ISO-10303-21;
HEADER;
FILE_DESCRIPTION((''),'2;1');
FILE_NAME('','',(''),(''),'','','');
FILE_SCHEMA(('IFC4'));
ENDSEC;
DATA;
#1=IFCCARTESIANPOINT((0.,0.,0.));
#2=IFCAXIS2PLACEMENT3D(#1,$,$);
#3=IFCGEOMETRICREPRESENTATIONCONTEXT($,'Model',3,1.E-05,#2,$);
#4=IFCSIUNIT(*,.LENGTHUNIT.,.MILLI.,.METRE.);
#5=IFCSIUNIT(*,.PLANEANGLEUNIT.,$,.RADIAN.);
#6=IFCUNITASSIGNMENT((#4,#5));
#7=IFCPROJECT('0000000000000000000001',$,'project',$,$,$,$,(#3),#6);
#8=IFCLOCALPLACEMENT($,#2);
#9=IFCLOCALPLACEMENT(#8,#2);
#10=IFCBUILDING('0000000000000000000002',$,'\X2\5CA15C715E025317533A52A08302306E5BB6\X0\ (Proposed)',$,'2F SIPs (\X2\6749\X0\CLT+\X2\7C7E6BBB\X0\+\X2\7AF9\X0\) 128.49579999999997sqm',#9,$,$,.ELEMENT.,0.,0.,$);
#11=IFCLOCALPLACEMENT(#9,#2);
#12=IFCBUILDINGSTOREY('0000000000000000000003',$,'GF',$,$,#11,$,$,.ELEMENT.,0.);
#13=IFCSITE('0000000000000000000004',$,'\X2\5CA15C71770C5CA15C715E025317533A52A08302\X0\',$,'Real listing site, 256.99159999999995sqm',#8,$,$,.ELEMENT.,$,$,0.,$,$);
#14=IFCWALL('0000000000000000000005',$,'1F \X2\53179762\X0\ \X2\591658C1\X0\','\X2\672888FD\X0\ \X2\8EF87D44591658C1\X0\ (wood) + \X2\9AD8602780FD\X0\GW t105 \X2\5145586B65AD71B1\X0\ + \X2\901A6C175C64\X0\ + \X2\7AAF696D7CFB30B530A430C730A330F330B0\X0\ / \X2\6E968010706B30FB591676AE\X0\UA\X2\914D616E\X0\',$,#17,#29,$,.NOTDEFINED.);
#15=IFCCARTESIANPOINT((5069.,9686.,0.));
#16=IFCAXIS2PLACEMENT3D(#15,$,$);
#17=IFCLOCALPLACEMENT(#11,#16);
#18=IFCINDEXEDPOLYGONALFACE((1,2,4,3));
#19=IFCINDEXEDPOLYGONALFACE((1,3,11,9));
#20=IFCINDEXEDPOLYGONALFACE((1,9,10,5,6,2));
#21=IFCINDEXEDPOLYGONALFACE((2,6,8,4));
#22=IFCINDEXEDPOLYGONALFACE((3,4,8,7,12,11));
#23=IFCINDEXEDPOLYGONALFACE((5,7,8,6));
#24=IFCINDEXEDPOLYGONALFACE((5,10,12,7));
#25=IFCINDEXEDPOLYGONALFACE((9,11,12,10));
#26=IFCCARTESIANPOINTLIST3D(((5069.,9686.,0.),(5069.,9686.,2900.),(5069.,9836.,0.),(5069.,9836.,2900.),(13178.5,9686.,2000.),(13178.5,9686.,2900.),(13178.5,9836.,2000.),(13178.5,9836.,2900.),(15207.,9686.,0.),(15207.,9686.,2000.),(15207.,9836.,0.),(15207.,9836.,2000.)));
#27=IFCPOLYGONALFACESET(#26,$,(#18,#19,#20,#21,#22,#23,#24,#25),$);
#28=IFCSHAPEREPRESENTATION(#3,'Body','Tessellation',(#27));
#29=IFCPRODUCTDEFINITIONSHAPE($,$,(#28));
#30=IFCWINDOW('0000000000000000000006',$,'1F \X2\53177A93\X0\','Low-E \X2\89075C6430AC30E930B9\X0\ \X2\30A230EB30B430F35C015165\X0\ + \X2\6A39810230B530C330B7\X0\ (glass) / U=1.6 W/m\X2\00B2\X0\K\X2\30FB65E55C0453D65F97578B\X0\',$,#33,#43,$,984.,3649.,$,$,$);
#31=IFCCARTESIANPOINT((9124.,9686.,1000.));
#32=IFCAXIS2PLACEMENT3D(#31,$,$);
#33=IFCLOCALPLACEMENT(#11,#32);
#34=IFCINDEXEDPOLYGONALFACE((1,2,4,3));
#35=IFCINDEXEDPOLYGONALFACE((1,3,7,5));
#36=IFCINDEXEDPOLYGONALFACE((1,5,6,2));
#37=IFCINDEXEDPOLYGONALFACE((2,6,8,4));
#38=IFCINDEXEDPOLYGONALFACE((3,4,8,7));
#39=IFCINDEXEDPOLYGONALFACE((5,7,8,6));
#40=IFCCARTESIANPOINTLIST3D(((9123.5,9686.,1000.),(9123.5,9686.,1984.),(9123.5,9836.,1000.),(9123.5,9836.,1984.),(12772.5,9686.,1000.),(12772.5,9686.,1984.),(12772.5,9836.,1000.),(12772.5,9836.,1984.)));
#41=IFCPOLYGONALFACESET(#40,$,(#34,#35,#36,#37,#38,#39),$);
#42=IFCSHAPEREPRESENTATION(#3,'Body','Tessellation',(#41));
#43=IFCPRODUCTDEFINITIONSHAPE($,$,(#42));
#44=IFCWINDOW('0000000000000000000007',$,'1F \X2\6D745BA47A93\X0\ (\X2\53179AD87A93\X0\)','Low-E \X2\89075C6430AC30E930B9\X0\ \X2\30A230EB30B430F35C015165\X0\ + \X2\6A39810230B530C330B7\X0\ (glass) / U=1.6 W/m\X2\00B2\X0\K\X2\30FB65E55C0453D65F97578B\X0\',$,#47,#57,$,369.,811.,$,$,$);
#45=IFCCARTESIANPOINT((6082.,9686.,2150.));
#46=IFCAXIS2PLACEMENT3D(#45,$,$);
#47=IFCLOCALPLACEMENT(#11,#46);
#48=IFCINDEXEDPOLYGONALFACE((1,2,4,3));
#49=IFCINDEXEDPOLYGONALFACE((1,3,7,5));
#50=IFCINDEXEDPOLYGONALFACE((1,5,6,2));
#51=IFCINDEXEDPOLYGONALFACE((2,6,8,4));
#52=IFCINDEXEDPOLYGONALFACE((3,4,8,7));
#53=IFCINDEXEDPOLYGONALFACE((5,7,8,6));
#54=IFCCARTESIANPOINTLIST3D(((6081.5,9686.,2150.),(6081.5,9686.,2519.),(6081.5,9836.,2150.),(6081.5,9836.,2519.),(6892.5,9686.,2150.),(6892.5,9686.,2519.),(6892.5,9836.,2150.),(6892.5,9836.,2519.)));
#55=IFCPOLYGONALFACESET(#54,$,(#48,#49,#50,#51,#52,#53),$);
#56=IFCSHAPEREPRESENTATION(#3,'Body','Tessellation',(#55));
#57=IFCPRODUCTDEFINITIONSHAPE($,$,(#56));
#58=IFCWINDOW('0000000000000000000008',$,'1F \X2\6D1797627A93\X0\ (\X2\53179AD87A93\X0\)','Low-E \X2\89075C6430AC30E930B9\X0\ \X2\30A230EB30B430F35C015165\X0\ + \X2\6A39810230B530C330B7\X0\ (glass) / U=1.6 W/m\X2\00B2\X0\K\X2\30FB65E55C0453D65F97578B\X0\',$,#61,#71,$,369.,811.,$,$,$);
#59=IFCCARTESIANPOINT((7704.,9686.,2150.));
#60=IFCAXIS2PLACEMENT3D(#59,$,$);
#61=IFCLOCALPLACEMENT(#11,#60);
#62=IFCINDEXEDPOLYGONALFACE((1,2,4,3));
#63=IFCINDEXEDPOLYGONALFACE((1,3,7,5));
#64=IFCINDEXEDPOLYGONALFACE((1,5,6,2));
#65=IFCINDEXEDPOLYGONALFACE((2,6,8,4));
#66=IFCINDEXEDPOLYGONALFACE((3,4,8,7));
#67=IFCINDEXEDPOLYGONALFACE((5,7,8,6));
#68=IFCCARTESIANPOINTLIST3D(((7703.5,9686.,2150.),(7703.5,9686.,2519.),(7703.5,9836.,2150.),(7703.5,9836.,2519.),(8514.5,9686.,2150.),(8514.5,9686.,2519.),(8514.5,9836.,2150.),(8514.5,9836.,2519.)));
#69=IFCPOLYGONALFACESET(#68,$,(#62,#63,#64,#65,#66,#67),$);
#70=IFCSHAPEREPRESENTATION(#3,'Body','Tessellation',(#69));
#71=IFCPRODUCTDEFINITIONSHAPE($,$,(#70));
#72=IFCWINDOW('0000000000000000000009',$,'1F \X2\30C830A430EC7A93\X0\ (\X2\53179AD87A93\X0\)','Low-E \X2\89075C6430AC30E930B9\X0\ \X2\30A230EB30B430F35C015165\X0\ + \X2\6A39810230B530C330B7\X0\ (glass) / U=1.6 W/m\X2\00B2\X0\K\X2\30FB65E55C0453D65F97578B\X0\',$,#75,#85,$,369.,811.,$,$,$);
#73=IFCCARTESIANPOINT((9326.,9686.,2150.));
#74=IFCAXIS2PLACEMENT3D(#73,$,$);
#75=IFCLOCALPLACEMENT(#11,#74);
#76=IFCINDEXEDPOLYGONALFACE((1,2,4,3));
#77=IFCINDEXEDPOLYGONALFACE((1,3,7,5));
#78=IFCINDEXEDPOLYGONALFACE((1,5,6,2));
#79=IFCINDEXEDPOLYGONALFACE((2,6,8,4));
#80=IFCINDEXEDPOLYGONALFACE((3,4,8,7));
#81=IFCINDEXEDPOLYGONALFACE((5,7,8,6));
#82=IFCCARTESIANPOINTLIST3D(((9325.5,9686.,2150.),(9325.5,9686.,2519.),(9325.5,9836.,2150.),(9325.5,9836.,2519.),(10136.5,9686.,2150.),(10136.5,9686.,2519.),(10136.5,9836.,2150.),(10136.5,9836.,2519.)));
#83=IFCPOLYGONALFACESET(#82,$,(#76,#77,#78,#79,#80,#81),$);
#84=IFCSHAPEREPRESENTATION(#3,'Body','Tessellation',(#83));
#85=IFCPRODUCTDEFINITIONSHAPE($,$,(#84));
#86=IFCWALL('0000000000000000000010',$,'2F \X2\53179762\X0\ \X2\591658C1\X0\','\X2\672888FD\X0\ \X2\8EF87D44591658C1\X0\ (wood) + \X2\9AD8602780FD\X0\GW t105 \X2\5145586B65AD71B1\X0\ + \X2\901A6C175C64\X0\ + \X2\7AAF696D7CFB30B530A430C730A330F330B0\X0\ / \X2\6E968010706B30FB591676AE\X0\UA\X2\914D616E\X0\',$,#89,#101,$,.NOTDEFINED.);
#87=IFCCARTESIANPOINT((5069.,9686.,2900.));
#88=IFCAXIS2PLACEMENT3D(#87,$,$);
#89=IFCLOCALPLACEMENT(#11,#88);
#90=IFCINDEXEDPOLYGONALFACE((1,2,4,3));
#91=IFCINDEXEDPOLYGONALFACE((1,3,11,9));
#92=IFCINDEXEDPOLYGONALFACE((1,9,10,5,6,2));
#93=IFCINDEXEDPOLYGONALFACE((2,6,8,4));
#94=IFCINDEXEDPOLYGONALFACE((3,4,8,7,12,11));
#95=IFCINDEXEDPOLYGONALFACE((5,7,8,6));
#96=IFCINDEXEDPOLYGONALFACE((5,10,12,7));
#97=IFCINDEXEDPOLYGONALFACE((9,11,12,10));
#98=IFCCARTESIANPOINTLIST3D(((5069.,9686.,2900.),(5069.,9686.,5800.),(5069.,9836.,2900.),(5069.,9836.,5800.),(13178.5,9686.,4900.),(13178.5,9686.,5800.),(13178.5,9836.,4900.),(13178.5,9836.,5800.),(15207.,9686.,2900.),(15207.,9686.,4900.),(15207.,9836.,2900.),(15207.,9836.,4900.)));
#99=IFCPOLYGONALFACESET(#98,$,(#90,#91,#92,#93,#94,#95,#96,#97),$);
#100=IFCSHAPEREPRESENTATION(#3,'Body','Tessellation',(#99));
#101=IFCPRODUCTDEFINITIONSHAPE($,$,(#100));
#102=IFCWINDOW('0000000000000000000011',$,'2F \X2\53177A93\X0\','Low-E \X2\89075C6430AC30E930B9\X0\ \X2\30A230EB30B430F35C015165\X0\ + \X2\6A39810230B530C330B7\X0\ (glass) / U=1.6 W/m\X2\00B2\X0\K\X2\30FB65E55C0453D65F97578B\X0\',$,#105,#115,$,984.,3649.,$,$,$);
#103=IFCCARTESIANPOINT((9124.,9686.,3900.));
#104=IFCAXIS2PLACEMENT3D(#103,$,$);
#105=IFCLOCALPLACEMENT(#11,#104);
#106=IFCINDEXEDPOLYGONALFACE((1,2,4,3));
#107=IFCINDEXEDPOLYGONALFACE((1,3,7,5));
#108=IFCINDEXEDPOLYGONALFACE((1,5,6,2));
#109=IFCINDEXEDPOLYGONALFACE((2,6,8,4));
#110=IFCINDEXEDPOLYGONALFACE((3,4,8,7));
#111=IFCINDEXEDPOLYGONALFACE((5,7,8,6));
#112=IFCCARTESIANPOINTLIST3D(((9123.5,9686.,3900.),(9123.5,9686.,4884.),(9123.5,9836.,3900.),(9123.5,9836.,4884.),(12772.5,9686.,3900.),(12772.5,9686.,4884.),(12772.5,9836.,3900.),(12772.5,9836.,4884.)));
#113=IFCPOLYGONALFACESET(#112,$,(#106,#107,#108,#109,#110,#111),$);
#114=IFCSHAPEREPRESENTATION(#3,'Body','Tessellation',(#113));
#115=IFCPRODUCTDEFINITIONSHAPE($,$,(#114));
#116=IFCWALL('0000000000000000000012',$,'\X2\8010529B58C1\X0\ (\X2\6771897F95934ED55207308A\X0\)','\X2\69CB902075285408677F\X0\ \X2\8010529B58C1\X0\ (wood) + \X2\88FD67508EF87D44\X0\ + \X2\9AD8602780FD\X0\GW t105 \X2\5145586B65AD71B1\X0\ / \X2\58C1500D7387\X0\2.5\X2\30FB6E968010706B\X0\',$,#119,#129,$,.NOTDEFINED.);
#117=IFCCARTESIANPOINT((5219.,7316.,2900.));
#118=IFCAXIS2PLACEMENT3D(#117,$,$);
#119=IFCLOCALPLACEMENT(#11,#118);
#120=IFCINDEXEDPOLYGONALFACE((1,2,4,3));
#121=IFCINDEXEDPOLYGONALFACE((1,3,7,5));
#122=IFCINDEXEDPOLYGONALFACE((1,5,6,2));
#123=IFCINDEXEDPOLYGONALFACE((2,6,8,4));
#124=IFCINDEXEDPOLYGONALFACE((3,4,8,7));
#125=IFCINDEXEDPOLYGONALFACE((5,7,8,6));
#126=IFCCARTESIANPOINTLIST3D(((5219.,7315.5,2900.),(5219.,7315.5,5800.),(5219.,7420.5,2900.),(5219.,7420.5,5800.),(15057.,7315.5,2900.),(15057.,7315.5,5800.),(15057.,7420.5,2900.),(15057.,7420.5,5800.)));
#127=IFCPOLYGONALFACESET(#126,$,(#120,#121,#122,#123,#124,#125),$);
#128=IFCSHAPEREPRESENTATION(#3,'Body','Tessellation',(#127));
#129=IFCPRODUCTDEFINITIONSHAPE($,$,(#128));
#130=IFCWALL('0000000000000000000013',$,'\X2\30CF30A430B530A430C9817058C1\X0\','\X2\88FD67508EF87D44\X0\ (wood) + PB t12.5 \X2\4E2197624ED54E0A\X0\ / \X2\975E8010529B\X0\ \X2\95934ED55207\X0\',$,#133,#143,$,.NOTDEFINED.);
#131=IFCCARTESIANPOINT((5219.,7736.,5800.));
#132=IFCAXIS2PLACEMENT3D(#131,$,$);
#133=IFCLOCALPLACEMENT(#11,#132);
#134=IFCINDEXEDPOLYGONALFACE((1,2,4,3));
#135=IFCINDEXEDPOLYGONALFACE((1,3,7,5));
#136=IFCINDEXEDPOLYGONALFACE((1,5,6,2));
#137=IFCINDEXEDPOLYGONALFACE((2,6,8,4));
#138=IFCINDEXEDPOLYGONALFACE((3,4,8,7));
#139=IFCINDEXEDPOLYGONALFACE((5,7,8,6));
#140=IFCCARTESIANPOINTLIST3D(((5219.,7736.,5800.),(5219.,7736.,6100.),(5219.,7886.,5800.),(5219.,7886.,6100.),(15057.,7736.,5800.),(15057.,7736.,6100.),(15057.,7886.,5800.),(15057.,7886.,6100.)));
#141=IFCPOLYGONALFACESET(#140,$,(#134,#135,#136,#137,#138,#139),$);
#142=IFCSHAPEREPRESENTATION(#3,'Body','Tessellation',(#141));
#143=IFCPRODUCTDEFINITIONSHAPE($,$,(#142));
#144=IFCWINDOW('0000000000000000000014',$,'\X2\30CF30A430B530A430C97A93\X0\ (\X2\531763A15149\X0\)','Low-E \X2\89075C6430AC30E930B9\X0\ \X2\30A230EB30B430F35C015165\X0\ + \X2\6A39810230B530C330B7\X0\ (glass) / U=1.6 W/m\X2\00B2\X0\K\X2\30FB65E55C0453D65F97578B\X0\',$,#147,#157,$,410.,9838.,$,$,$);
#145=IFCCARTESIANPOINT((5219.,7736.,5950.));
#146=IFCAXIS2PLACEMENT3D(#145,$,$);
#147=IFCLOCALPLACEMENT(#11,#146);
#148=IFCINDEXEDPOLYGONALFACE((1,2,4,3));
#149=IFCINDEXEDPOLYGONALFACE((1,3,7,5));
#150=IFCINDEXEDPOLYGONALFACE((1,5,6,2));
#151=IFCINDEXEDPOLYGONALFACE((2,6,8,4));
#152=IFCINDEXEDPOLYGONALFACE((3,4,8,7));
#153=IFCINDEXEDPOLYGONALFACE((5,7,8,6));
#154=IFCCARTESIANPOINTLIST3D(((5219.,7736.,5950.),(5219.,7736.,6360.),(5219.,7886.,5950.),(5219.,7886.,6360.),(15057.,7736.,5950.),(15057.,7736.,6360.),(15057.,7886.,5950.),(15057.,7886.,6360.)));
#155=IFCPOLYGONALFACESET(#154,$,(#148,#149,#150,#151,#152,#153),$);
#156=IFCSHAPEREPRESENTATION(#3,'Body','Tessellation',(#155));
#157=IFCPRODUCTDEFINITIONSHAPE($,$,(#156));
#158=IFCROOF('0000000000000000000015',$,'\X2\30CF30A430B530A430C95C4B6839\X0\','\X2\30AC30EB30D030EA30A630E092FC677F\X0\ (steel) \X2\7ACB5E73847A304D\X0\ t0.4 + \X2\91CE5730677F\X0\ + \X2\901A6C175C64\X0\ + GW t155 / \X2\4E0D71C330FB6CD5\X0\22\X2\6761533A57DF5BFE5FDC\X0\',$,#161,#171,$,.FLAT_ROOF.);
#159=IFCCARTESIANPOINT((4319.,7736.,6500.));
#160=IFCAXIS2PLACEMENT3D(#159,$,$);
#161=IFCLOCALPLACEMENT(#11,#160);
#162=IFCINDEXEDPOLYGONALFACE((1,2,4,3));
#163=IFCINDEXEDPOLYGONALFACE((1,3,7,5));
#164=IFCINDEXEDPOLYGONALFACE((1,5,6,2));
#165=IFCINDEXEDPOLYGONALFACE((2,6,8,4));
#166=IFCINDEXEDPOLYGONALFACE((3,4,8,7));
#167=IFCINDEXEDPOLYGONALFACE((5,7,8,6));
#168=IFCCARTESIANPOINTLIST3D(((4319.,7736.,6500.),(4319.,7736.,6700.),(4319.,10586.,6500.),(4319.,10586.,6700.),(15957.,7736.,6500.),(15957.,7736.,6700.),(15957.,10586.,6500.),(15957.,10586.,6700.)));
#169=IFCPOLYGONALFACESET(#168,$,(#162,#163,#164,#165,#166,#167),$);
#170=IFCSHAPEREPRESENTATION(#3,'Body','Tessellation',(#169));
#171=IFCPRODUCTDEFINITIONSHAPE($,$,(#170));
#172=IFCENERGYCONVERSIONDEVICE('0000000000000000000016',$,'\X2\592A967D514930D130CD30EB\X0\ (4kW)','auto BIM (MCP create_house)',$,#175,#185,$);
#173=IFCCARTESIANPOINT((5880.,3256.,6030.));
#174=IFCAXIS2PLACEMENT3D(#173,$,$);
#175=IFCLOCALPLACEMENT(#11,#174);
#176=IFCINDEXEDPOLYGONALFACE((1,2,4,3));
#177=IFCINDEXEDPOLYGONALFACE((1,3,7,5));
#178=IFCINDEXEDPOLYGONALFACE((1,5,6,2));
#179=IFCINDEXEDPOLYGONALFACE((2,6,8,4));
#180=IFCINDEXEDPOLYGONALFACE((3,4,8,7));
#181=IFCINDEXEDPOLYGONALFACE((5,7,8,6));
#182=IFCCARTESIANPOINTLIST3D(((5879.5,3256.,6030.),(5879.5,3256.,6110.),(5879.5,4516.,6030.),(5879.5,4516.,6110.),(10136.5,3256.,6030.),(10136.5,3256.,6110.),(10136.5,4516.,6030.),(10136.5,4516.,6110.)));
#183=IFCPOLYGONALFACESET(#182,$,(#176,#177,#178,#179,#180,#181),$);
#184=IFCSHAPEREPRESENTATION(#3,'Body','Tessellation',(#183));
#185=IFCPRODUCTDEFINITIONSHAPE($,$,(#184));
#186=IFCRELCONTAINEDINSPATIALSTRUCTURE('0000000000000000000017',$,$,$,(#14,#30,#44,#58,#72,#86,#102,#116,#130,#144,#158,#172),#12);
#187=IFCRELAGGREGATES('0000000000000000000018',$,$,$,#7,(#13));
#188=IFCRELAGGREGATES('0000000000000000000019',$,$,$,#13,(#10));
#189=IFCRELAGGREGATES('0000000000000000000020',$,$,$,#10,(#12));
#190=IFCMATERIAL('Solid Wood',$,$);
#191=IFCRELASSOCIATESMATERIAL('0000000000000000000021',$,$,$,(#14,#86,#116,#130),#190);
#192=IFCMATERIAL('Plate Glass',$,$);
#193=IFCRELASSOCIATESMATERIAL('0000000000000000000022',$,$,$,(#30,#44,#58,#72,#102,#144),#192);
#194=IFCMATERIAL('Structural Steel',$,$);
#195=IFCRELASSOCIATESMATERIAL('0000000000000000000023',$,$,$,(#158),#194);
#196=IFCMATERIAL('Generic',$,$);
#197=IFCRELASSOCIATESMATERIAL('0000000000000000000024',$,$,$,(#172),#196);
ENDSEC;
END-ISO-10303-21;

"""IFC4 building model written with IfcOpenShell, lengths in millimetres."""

from ifc_helpers import new_model, si_unit, frame, frame_2d, origin, place, context, project, spatial, rectangle, extrude, material, element, fill, save


model = new_model("IFC4")

# Units and contexts
model_context = context("Model", 3, precision=1e-05, world=origin())
ifc_project = project(units=[si_unit("LENGTHUNIT", "METRE", prefix="MILLI"), si_unit("PLANEANGLEUNIT", "RADIAN")], contexts=[model_context])

# Site, building, storey
site_placement = place(None, origin())
site = spatial("IfcSite", under=ifc_project, at=site_placement, Name="岡山県岡山市北区加茂", ObjectType="Real listing site, 256.99159999999995sqm", CompositionType="ELEMENT", RefElevation=0.0)
building_placement = place(site_placement, origin())
building = spatial("IfcBuilding", under=site, at=building_placement, Name="岡山市北区加茂の家 (Proposed)", ObjectType="2F SIPs (杉CLT+籾殻+竹) 128.49579999999997sqm", CompositionType="ELEMENT", ElevationOfRefHeight=0.0, ElevationOfTerrain=0.0)
storey_placement = place(building_placement, origin())
storey = spatial("IfcBuildingStorey", under=building, at=storey_placement, Name="GF", CompositionType="ELEMENT", Elevation=0.0)

# Wall, openings, windows
ifc_material_1 = material(Name="Solid Wood")
wall_1_placement = place(storey_placement, frame((5069.0, 9686.0, 0.0)))
wall_1 = element("IfcWall", 1, at=wall_1_placement, inside=storey, material=ifc_material_1, Name="1F 北面 外壁", Description="木製 軸組外壁 (wood) + 高性能GW t105 充填断熱 + 通気層 + 窯業系サイディング / 準耐火・外皮UA配慮", PredefinedType="NOTDEFINED", context=model_context, shape_type="SweptSolid", body=[
    extrude(rectangle(XDim=10138.0, YDim=150.0, at=frame_2d((5069.0, 75.0))), frame((5069.0, 9686.0, 0.0)), (0.0, 0.0, 1.0), 2900.0),
])
opening_1_placement = place(storey_placement, frame((9124.0, 9686.0, 1000.0)))
opening_1 = element("IfcOpeningElement", 2, at=opening_1_placement, cuts=wall_1, PredefinedType="NOTDEFINED", context=model_context, shape_type="SweptSolid", body=[
    extrude(rectangle(XDim=3649.0, YDim=150.0, at=frame_2d((1824.0, 75.0))), frame((9124.0, 9686.0, 1000.0)), (0.0, 0.0, 1.0), 984.0),
])
opening_2_placement = place(storey_placement, frame((6082.0, 9686.0, 2150.0)))
opening_2 = element("IfcOpeningElement", 3, at=opening_2_placement, cuts=wall_1, PredefinedType="NOTDEFINED", context=model_context, shape_type="SweptSolid", body=[
    extrude(rectangle(XDim=811.0, YDim=150.0, at=frame_2d((405.0, 75.0))), frame((6082.0, 9686.0, 2150.0)), (0.0, 0.0, 1.0), 369.0),
])
opening_3_placement = place(storey_placement, frame((7704.0, 9686.0, 2150.0)))
opening_3 = element("IfcOpeningElement", 4, at=opening_3_placement, cuts=wall_1, PredefinedType="NOTDEFINED", context=model_context, shape_type="SweptSolid", body=[
    extrude(rectangle(XDim=811.0, YDim=150.0, at=frame_2d((405.0, 75.0))), frame((7704.0, 9686.0, 2150.0)), (0.0, 0.0, 1.0), 369.0),
])
opening_4_placement = place(storey_placement, frame((9326.0, 9686.0, 2150.0)))
opening_4 = element("IfcOpeningElement", 5, at=opening_4_placement, cuts=wall_1, PredefinedType="NOTDEFINED", context=model_context, shape_type="SweptSolid", body=[
    extrude(rectangle(XDim=811.0, YDim=150.0, at=frame_2d((405.0, 75.0))), frame((9326.0, 9686.0, 2150.0)), (0.0, 0.0, 1.0), 369.0),
])
ifc_material_2 = material(Name="Plate Glass")
window_1_placement = place(storey_placement, frame((9124.0, 9686.0, 1000.0)))
window_1 = element("IfcWindow", 6, at=window_1_placement, inside=storey, material=ifc_material_2, Name="1F 北窓", Description="Low-E 複層ガラス アルゴン封入 + 樹脂サッシ (glass) / U=1.6 W/m²K・日射取得型", OverallHeight=984.0, OverallWidth=3649.0, context=model_context, shape_type="SweptSolid", body=[
    extrude(rectangle(XDim=3649.0, YDim=150.0, at=frame_2d((1824.0, 75.0))), frame((9124.0, 9686.0, 1000.0)), (0.0, 0.0, 1.0), 984.0),
])
fill(opening_1, window_1)
window_2_placement = place(storey_placement, frame((6082.0, 9686.0, 2150.0)))
window_2 = element("IfcWindow", 7, at=window_2_placement, inside=storey, material=ifc_material_2, Name="1F 浴室窓 (北高窓)", Description="Low-E 複層ガラス アルゴン封入 + 樹脂サッシ (glass) / U=1.6 W/m²K・日射取得型", OverallHeight=369.0, OverallWidth=811.0, context=model_context, shape_type="SweptSolid", body=[
    extrude(rectangle(XDim=811.0, YDim=150.0, at=frame_2d((405.0, 75.0))), frame((6082.0, 9686.0, 2150.0)), (0.0, 0.0, 1.0), 369.0),
])
fill(opening_2, window_2)
window_3_placement = place(storey_placement, frame((7704.0, 9686.0, 2150.0)))
window_3 = element("IfcWindow", 8, at=window_3_placement, inside=storey, material=ifc_material_2, Name="1F 洗面窓 (北高窓)", Description="Low-E 複層ガラス アルゴン封入 + 樹脂サッシ (glass) / U=1.6 W/m²K・日射取得型", OverallHeight=369.0, OverallWidth=811.0, context=model_context, shape_type="SweptSolid", body=[
    extrude(rectangle(XDim=811.0, YDim=150.0, at=frame_2d((405.0, 75.0))), frame((7704.0, 9686.0, 2150.0)), (0.0, 0.0, 1.0), 369.0),
])
fill(opening_3, window_3)
window_4_placement = place(storey_placement, frame((9326.0, 9686.0, 2150.0)))
window_4 = element("IfcWindow", 9, at=window_4_placement, inside=storey, material=ifc_material_2, Name="1F トイレ窓 (北高窓)", Description="Low-E 複層ガラス アルゴン封入 + 樹脂サッシ (glass) / U=1.6 W/m²K・日射取得型", OverallHeight=369.0, OverallWidth=811.0, context=model_context, shape_type="SweptSolid", body=[
    extrude(rectangle(XDim=811.0, YDim=150.0, at=frame_2d((405.0, 75.0))), frame((9326.0, 9686.0, 2150.0)), (0.0, 0.0, 1.0), 369.0),
])
fill(opening_4, window_4)

# Wall, opening, window
wall_2_placement = place(storey_placement, frame((5069.0, 9686.0, 2900.0)))
wall_2 = element("IfcWall", 10, at=wall_2_placement, inside=storey, material=ifc_material_1, Name="2F 北面 外壁", Description="木製 軸組外壁 (wood) + 高性能GW t105 充填断熱 + 通気層 + 窯業系サイディング / 準耐火・外皮UA配慮", PredefinedType="NOTDEFINED", context=model_context, shape_type="SweptSolid", body=[
    extrude(rectangle(XDim=10138.0, YDim=150.0, at=frame_2d((5069.0, 75.0))), frame((5069.0, 9686.0, 2900.0)), (0.0, 0.0, 1.0), 2900.0),
])
opening_5_placement = place(storey_placement, frame((9124.0, 9686.0, 3900.0)))
opening_5 = element("IfcOpeningElement", 11, at=opening_5_placement, cuts=wall_2, PredefinedType="NOTDEFINED", context=model_context, shape_type="SweptSolid", body=[
    extrude(rectangle(XDim=3649.0, YDim=150.0, at=frame_2d((1824.0, 75.0))), frame((9124.0, 9686.0, 3900.0)), (0.0, 0.0, 1.0), 984.0),
])
window_5_placement = place(storey_placement, frame((9124.0, 9686.0, 3900.0)))
window_5 = element("IfcWindow", 12, at=window_5_placement, inside=storey, material=ifc_material_2, Name="2F 北窓", Description="Low-E 複層ガラス アルゴン封入 + 樹脂サッシ (glass) / U=1.6 W/m²K・日射取得型", OverallHeight=984.0, OverallWidth=3649.0, context=model_context, shape_type="SweptSolid", body=[
    extrude(rectangle(XDim=3649.0, YDim=150.0, at=frame_2d((1824.0, 75.0))), frame((9124.0, 9686.0, 3900.0)), (0.0, 0.0, 1.0), 984.0),
])
fill(opening_5, window_5)

# Wall
wall_3_placement = place(storey_placement, frame((5219.0, 7316.0, 2900.0)))
element("IfcWall", 13, at=wall_3_placement, inside=storey, material=ifc_material_1, Name="耐力壁 (東西間仕切り)", Description="構造用合板 耐力壁 (wood) + 製材軸組 + 高性能GW t105 充填断熱 / 壁倍率2.5・準耐火", PredefinedType="NOTDEFINED", context=model_context, shape_type="SweptSolid", body=[
    extrude(rectangle(XDim=9838.0, YDim=105.0, at=frame_2d((4919.0, 52.0))), frame((5219.0, 7316.0, 2900.0)), (0.0, 0.0, 1.0), 2900.0),
])

# Wall, opening, window
wall_4_placement = place(storey_placement, frame((5219.0, 7736.0, 5800.0)))
wall_4 = element("IfcWall", 14, at=wall_4_placement, inside=storey, material=ifc_material_1, Name="ハイサイド腰壁", Description="製材軸組 (wood) + PB t12.5 両面仕上 / 非耐力 間仕切", PredefinedType="NOTDEFINED", context=model_context, shape_type="SweptSolid", body=[
    extrude(rectangle(XDim=9838.0, YDim=150.0, at=frame_2d((4919.0, 75.0))), frame((5219.0, 7736.0, 5800.0)), (0.0, 0.0, 1.0), 700.0),
])
opening_6_placement = place(storey_placement, frame((5219.0, 7736.0, 5950.0)))
opening_6 = element("IfcOpeningElement", 15, at=opening_6_placement, cuts=wall_4, PredefinedType="NOTDEFINED", context=model_context, shape_type="SweptSolid", body=[
    extrude(rectangle(XDim=9838.0, YDim=150.0, at=frame_2d((4919.0, 75.0))), frame((5219.0, 7736.0, 5950.0)), (0.0, 0.0, 1.0), 410.0),
])
window_6_placement = place(storey_placement, frame((5219.0, 7736.0, 5950.0)))
window_6 = element("IfcWindow", 16, at=window_6_placement, inside=storey, material=ifc_material_2, Name="ハイサイド窓 (北採光)", Description="Low-E 複層ガラス アルゴン封入 + 樹脂サッシ (glass) / U=1.6 W/m²K・日射取得型", OverallHeight=410.0, OverallWidth=9838.0, context=model_context, shape_type="SweptSolid", body=[
    extrude(rectangle(XDim=9838.0, YDim=150.0, at=frame_2d((4919.0, 75.0))), frame((5219.0, 7736.0, 5950.0)), (0.0, 0.0, 1.0), 410.0),
])
fill(opening_6, window_6)

# Roof
ifc_material_3 = material(Name="Structural Steel")
roof_placement = place(storey_placement, frame((4319.0, 7736.0, 6500.0)))
element("IfcRoof", 17, at=roof_placement, inside=storey, material=ifc_material_3, Name="ハイサイド屋根", Description="ガルバリウム鋼板 (steel) 立平葺き t0.4 + 野地板 + 通気層 + GW t155 / 不燃・法22条区域対応", PredefinedType="FLAT_ROOF", context=model_context, shape_type="SweptSolid", body=[
    extrude(rectangle(XDim=11638.0, YDim=2850.0, at=frame_2d((5819.0, 1425.0))), frame((4319.0, 7736.0, 6500.0)), (0.0, 0.0, 1.0), 200.0),
])

# Energy conversion device
ifc_material_4 = material(Name="Generic")
energy_conversion_device_placement = place(storey_placement, frame((5880.0, 3256.0, 6030.0)))
element("IfcEnergyConversionDevice", 18, at=energy_conversion_device_placement, inside=storey, material=ifc_material_4, Name="太陽光パネル (4kW)", Description="auto BIM (MCP create_house)", context=model_context, shape_type="SweptSolid", body=[
    extrude(rectangle(XDim=4257.0, YDim=1260.0, at=frame_2d((2128.0, 630.0))), frame((5880.0, 3256.0, 6030.0)), (0.0, 0.0, 1.0), 80.0),
])

save(model, "model.ifc")
